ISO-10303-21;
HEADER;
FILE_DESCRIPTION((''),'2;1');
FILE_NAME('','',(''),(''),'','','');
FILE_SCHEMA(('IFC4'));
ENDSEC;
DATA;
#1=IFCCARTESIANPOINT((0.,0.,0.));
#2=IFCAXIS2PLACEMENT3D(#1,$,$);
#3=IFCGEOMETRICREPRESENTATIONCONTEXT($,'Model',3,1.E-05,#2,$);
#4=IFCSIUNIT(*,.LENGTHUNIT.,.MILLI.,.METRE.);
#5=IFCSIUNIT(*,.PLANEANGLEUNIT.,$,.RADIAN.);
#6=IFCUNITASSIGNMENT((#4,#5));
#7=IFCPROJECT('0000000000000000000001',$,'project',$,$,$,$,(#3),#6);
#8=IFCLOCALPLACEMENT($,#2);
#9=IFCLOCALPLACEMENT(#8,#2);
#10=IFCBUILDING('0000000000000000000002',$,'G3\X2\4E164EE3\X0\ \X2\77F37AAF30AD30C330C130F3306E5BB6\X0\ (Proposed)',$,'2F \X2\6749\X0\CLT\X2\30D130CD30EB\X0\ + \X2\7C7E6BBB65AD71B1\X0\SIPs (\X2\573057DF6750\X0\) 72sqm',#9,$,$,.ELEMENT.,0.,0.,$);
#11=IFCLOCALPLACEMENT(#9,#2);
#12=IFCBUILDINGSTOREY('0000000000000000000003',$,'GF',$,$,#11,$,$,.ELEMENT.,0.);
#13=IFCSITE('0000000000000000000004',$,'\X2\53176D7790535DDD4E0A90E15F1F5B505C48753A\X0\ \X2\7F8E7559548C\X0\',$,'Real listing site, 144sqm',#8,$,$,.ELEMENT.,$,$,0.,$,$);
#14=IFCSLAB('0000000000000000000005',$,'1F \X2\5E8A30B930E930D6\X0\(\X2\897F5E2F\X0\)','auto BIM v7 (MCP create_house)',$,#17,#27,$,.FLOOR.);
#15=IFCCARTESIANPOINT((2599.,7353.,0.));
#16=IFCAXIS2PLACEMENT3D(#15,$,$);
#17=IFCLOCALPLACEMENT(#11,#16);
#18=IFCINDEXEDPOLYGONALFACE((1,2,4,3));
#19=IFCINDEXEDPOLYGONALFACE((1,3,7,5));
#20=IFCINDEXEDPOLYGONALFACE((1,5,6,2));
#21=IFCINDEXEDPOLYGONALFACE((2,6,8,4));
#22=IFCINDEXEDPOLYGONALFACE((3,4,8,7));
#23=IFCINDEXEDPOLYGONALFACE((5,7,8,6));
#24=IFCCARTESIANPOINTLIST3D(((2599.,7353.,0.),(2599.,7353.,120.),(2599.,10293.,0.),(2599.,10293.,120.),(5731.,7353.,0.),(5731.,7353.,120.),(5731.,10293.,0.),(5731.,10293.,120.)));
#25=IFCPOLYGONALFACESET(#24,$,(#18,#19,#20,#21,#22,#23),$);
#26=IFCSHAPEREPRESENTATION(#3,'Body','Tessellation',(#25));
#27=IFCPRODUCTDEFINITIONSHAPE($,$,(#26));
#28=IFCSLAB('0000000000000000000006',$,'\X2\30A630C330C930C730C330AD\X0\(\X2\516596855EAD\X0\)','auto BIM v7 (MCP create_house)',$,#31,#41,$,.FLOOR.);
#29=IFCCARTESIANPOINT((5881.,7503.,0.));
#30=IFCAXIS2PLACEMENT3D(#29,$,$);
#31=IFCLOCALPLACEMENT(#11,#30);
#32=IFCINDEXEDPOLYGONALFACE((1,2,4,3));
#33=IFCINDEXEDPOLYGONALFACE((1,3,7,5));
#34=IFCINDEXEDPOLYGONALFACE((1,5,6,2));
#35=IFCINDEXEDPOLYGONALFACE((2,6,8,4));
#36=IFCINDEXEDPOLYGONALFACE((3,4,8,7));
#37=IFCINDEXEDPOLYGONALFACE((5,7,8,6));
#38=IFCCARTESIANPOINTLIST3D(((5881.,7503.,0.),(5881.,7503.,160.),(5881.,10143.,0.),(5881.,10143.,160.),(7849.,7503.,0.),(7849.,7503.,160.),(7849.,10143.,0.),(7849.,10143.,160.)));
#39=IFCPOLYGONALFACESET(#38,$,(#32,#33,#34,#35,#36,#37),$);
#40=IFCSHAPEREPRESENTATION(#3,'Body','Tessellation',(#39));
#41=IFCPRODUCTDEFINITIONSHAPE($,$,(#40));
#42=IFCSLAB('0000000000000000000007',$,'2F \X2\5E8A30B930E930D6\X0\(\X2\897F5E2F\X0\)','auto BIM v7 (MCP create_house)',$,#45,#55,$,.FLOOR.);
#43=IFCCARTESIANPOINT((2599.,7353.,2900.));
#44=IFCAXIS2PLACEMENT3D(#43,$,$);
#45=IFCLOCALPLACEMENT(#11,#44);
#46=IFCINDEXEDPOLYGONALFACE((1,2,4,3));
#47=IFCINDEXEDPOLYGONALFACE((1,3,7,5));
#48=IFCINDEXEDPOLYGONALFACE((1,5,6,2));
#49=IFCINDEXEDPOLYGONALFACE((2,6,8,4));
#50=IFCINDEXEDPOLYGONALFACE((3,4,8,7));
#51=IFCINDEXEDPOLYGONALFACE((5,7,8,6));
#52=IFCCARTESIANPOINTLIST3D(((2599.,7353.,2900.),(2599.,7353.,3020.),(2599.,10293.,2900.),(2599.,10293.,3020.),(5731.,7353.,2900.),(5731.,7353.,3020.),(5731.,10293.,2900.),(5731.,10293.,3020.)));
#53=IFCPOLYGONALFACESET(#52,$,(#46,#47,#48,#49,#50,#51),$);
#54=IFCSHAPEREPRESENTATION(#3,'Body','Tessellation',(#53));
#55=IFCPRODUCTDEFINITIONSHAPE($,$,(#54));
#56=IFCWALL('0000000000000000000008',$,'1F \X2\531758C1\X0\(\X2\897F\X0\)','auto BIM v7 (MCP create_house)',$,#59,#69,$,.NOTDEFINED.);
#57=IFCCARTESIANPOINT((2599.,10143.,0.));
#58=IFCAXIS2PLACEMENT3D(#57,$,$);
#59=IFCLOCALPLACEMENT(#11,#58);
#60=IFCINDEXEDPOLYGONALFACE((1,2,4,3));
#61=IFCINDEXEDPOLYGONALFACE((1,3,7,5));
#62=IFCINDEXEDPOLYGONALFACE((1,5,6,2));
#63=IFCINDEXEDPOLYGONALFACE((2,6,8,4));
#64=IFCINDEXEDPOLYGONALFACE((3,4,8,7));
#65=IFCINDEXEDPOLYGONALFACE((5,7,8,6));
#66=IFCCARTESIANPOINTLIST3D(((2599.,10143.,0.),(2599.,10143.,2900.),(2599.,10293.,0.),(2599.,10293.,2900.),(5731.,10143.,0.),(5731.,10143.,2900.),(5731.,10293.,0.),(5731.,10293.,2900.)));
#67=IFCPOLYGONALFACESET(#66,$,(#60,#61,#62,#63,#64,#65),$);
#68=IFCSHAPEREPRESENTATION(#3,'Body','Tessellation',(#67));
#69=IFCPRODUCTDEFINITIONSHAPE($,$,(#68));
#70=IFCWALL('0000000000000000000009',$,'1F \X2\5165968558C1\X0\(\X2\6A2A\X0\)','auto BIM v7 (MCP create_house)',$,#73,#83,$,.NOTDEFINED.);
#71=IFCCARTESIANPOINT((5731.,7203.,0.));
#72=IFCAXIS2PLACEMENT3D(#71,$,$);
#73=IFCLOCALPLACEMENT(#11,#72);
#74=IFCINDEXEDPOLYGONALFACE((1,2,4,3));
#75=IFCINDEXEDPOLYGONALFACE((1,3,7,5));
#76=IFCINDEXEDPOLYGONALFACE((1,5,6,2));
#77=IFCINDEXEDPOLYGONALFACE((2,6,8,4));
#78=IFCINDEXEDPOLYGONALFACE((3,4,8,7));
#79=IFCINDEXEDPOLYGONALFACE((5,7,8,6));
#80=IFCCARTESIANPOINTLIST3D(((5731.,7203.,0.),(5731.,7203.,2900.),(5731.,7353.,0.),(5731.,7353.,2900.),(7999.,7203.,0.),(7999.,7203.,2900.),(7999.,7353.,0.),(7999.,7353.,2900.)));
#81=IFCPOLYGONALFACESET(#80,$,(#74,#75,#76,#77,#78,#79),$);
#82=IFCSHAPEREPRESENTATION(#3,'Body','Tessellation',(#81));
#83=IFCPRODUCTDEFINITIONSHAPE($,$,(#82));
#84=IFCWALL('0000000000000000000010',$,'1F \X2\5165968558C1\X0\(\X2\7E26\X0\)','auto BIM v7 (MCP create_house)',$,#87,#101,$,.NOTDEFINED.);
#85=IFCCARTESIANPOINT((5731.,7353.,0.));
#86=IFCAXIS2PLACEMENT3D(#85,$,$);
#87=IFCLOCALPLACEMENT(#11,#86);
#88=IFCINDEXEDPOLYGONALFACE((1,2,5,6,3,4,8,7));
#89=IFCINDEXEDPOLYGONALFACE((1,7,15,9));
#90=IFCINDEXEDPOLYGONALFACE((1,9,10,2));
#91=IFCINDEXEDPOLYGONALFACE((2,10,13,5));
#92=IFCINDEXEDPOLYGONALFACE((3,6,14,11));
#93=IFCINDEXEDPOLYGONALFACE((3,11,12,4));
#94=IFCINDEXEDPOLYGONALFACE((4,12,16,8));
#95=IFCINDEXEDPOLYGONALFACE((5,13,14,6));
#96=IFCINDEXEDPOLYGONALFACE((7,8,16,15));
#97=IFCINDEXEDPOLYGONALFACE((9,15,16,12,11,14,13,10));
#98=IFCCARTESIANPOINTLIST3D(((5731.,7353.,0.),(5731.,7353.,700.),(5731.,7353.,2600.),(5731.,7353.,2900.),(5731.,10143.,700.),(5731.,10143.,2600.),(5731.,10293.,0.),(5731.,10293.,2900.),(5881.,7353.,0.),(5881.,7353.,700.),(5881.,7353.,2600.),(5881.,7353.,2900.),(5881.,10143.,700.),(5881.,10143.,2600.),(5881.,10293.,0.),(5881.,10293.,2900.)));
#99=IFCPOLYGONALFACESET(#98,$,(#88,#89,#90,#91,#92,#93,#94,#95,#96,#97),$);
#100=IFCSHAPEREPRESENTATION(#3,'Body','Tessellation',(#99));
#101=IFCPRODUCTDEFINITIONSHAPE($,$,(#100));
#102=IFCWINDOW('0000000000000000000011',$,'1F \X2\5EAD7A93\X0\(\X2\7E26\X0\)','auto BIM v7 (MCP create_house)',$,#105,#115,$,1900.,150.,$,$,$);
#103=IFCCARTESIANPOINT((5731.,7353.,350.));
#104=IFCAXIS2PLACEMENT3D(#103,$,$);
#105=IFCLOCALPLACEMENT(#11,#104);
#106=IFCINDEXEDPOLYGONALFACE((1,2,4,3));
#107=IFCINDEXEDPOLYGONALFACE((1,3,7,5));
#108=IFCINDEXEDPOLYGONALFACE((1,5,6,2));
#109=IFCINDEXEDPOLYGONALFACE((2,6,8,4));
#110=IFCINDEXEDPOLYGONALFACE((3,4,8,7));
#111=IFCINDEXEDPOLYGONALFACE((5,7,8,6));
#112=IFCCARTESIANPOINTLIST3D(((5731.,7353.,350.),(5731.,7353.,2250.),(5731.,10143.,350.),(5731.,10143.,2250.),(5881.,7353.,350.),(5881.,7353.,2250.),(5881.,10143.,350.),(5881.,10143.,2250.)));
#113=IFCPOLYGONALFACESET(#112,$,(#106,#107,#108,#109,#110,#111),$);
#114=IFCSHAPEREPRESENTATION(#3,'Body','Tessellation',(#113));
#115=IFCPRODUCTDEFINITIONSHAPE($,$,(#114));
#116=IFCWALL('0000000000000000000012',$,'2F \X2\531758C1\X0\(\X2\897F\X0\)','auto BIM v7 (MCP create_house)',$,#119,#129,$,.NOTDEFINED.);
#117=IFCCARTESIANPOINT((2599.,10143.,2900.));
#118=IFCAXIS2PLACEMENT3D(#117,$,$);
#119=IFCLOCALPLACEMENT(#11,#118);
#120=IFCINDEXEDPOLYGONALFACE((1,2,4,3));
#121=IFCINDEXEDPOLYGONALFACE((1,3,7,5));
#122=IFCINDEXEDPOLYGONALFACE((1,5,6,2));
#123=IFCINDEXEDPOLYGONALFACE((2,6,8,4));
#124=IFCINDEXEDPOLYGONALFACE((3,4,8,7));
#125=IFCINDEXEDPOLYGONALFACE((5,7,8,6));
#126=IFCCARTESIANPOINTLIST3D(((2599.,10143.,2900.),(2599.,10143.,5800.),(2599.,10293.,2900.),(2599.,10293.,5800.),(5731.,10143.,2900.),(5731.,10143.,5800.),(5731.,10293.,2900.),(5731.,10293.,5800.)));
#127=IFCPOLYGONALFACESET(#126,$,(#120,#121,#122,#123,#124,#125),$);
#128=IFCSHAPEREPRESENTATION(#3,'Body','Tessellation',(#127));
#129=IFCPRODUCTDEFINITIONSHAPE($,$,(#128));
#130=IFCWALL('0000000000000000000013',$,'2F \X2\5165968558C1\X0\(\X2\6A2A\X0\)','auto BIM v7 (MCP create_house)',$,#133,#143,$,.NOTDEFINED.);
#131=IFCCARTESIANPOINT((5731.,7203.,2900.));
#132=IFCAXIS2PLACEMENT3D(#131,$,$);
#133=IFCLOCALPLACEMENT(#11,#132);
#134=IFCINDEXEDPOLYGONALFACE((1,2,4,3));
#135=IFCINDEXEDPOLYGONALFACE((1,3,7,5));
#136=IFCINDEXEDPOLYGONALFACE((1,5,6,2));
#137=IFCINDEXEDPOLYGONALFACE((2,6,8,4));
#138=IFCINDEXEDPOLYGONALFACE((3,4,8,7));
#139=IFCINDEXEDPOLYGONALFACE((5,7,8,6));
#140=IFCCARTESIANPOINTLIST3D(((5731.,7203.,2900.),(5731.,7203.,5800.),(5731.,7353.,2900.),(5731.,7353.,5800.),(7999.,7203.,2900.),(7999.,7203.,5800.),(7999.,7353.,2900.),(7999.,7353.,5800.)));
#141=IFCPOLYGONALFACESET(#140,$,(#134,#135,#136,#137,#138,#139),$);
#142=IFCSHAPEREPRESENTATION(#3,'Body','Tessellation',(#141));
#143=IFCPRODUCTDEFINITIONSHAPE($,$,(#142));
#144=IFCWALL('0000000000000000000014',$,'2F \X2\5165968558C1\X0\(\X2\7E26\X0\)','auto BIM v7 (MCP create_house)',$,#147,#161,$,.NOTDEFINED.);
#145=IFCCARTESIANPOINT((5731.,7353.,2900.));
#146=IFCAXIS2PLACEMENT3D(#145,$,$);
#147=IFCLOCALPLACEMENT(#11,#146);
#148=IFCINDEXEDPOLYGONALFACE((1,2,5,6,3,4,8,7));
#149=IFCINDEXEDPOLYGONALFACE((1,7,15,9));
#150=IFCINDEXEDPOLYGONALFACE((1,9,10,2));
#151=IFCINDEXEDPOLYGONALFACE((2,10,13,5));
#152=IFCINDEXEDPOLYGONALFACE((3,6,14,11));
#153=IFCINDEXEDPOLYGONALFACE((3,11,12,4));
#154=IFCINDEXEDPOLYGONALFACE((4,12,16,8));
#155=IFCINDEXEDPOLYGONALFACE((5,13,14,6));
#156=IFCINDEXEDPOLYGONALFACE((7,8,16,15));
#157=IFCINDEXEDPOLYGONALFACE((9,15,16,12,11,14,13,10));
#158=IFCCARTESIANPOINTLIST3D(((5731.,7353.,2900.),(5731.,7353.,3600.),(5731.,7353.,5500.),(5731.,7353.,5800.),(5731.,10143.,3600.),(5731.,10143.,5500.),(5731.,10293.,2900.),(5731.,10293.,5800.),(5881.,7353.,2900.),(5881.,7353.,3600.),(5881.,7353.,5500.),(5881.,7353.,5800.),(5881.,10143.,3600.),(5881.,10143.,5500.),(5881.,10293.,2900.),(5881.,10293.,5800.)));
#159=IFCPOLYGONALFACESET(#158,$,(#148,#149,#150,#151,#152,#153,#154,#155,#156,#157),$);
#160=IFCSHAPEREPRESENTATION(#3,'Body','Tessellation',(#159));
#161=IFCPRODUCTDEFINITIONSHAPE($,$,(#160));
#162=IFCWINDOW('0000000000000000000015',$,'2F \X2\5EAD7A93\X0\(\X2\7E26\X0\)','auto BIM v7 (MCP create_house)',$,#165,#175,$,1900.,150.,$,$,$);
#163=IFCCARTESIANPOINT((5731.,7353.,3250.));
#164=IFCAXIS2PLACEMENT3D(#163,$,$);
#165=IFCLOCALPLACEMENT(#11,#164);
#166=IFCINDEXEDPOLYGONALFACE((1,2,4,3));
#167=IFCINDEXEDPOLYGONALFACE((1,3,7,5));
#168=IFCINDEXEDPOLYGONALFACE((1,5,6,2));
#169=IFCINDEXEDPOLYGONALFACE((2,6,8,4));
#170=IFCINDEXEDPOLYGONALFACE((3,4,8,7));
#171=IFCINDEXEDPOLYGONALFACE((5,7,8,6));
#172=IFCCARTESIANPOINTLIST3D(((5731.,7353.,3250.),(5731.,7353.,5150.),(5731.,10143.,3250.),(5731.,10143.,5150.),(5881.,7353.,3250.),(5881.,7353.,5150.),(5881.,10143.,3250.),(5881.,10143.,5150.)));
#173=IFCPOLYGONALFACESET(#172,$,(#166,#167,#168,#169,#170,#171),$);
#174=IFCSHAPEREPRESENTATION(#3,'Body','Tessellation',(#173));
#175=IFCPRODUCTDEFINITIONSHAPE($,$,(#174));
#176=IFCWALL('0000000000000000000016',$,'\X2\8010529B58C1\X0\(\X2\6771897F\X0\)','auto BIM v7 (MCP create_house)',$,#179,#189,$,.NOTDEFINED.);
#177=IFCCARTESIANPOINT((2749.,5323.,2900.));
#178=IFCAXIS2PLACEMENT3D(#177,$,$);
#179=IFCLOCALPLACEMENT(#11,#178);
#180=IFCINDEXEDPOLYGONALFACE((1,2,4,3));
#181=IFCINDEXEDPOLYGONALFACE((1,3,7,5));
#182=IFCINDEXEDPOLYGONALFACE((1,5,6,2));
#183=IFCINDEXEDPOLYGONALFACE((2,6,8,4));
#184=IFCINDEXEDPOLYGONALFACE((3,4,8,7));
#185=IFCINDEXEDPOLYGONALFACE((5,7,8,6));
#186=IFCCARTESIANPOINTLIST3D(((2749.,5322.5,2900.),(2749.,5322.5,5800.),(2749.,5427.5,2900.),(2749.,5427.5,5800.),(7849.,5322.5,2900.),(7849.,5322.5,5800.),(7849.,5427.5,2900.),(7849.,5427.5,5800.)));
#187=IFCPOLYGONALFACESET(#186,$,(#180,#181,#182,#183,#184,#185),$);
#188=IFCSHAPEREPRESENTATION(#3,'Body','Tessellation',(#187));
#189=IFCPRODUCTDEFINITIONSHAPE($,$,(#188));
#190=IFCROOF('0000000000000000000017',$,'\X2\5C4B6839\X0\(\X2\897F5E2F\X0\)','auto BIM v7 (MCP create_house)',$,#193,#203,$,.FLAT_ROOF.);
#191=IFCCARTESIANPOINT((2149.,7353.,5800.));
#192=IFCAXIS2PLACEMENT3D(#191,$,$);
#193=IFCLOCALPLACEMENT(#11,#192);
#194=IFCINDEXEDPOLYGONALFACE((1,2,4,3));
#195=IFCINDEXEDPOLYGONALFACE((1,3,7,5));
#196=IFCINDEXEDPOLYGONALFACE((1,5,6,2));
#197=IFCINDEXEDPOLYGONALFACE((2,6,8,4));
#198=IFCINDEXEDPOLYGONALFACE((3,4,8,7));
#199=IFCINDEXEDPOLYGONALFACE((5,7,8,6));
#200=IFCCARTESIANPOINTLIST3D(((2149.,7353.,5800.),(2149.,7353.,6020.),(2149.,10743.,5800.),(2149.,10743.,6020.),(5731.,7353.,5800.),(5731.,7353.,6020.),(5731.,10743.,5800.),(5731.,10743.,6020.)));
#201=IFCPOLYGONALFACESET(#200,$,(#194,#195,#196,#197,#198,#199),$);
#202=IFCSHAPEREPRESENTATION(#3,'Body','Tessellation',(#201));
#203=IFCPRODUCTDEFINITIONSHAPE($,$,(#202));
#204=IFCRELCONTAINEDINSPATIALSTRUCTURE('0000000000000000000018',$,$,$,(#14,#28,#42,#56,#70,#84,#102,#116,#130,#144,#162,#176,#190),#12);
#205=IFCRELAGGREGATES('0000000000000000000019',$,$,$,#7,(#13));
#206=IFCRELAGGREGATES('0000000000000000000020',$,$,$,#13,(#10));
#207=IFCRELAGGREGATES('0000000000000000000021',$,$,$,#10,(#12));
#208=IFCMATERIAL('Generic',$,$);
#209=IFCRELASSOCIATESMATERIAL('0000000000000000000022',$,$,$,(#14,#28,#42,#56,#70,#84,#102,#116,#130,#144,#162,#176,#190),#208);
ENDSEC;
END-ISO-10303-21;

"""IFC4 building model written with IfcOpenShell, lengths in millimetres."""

from ifc_helpers import new_model, si_unit, frame, frame_2d, origin, place, context, project, spatial, rectangle, extrude, material, element, fill, save


model = new_model("IFC4")

# Units and contexts
model_context = context("Model", 3, precision=1e-05, world=origin())
ifc_project = project(units=[si_unit("LENGTHUNIT", "METRE", prefix="MILLI"), si_unit("PLANEANGLEUNIT", "RADIAN")], contexts=[model_context])

# Site, building, storey
site_placement = place(None, origin())
site = spatial("IfcSite", under=ifc_project, at=site_placement, Name="北海道川上郡弟子屈町 美留和", ObjectType="Real listing site, 144sqm", CompositionType="ELEMENT", RefElevation=0.0)
building_placement = place(site_placement, origin())
building = spatial("IfcBuilding", under=site, at=building_placement, Name="G3世代 石窯キッチンの家 (Proposed)", ObjectType="2F 杉CLTパネル + 籾殻断熱SIPs (地域材) 72sqm", CompositionType="ELEMENT", ElevationOfRefHeight=0.0, ElevationOfTerrain=0.0)
storey_placement = place(building_placement, origin())
storey = spatial("IfcBuildingStorey", under=building, at=storey_placement, Name="GF", CompositionType="ELEMENT", Elevation=0.0)

# Slabs
ifc_material = material(Name="Generic")
slab_1_placement = place(storey_placement, frame((2599.0, 7353.0, 0.0)))
element("IfcSlab", 1, at=slab_1_placement, inside=storey, material=ifc_material, Name="1F 床スラブ(西帯)", Description="auto BIM v7 (MCP create_house)", PredefinedType="FLOOR", context=model_context, shape_type="SweptSolid", body=[
    extrude(rectangle(XDim=3132.0, YDim=2940.0, at=frame_2d((1566.0, 1470.0))), frame((2599.0, 7353.0, 0.0)), (0.0, 0.0, 1.0), 120.0),
])
slab_2_placement = place(storey_placement, frame((5881.0, 7503.0, 0.0)))
element("IfcSlab", 2, at=slab_2_placement, inside=storey, material=ifc_material, Name="ウッドデッキ(入隅庭)", Description="auto BIM v7 (MCP create_house)", PredefinedType="FLOOR", context=model_context, shape_type="SweptSolid", body=[
    extrude(rectangle(XDim=1968.0, YDim=2640.0, at=frame_2d((984.0, 1320.0))), frame((5881.0, 7503.0, 0.0)), (0.0, 0.0, 1.0), 160.0),
])
slab_3_placement = place(storey_placement, frame((2599.0, 7353.0, 2900.0)))
element("IfcSlab", 3, at=slab_3_placement, inside=storey, material=ifc_material, Name="2F 床スラブ(西帯)", Description="auto BIM v7 (MCP create_house)", PredefinedType="FLOOR", context=model_context, shape_type="SweptSolid", body=[
    extrude(rectangle(XDim=3132.0, YDim=2940.0, at=frame_2d((1566.0, 1470.0))), frame((2599.0, 7353.0, 2900.0)), (0.0, 0.0, 1.0), 120.0),
])

# Walls
wall_1_placement = place(storey_placement, frame((2599.0, 10143.0, 0.0)))
element("IfcWall", 4, at=wall_1_placement, inside=storey, material=ifc_material, Name="1F 北壁(西)", Description="auto BIM v7 (MCP create_house)", PredefinedType="NOTDEFINED", context=model_context, shape_type="SweptSolid", body=[
    extrude(rectangle(XDim=3132.0, YDim=150.0, at=frame_2d((1566.0, 75.0))), frame((2599.0, 10143.0, 0.0)), (0.0, 0.0, 1.0), 2900.0),
])
wall_2_placement = place(storey_placement, frame((5731.0, 7203.0, 0.0)))
element("IfcWall", 5, at=wall_2_placement, inside=storey, material=ifc_material, Name="1F 入隅壁(横)", Description="auto BIM v7 (MCP create_house)", PredefinedType="NOTDEFINED", context=model_context, shape_type="SweptSolid", body=[
    extrude(rectangle(XDim=2268.0, YDim=150.0, at=frame_2d((1134.0, 75.0))), frame((5731.0, 7203.0, 0.0)), (0.0, 0.0, 1.0), 2900.0),
])

# Wall, opening, window
wall_3_placement = place(storey_placement, frame((5731.0, 7353.0, 0.0)))
wall_3 = element("IfcWall", 6, at=wall_3_placement, inside=storey, material=ifc_material, Name="1F 入隅壁(縦)", Description="auto BIM v7 (MCP create_house)", PredefinedType="NOTDEFINED", context=model_context, shape_type="SweptSolid", body=[
    extrude(rectangle(XDim=150.0, YDim=2940.0, at=frame_2d((75.0, 1470.0))), frame((5731.0, 7353.0, 0.0)), (0.0, 0.0, 1.0), 2900.0),
])
opening_1_placement = place(storey_placement, frame((5731.0, 7353.0, 350.0)))
opening_1 = element("IfcOpeningElement", 7, at=opening_1_placement, cuts=wall_3, PredefinedType="NOTDEFINED", context=model_context, shape_type="SweptSolid", body=[
    extrude(rectangle(XDim=150.0, YDim=2790.0, at=frame_2d((75.0, 1395.0))), frame((5731.0, 7353.0, 350.0)), (0.0, 0.0, 1.0), 1900.0),
])
window_1_placement = place(storey_placement, frame((5731.0, 7353.0, 350.0)))
window_1 = element("IfcWindow", 8, at=window_1_placement, inside=storey, material=ifc_material, Name="1F 庭窓(縦)", Description="auto BIM v7 (MCP create_house)", OverallHeight=1900.0, OverallWidth=150.0, context=model_context, shape_type="SweptSolid", body=[
    extrude(rectangle(XDim=150.0, YDim=2790.0, at=frame_2d((75.0, 1395.0))), frame((5731.0, 7353.0, 350.0)), (0.0, 0.0, 1.0), 1900.0),
])
fill(opening_1, window_1)

# Walls
wall_4_placement = place(storey_placement, frame((2599.0, 10143.0, 2900.0)))
element("IfcWall", 9, at=wall_4_placement, inside=storey, material=ifc_material, Name="2F 北壁(西)", Description="auto BIM v7 (MCP create_house)", PredefinedType="NOTDEFINED", context=model_context, shape_type="SweptSolid", body=[
    extrude(rectangle(XDim=3132.0, YDim=150.0, at=frame_2d((1566.0, 75.0))), frame((2599.0, 10143.0, 2900.0)), (0.0, 0.0, 1.0), 2900.0),
])
wall_5_placement = place(storey_placement, frame((5731.0, 7203.0, 2900.0)))
element("IfcWall", 10, at=wall_5_placement, inside=storey, material=ifc_material, Name="2F 入隅壁(横)", Description="auto BIM v7 (MCP create_house)", PredefinedType="NOTDEFINED", context=model_context, shape_type="SweptSolid", body=[
    extrude(rectangle(XDim=2268.0, YDim=150.0, at=frame_2d((1134.0, 75.0))), frame((5731.0, 7203.0, 2900.0)), (0.0, 0.0, 1.0), 2900.0),
])

# Wall, opening, window
wall_6_placement = place(storey_placement, frame((5731.0, 7353.0, 2900.0)))
wall_6 = element("IfcWall", 11, at=wall_6_placement, inside=storey, material=ifc_material, Name="2F 入隅壁(縦)", Description="auto BIM v7 (MCP create_house)", PredefinedType="NOTDEFINED", context=model_context, shape_type="SweptSolid", body=[
    extrude(rectangle(XDim=150.0, YDim=2940.0, at=frame_2d((75.0, 1470.0))), frame((5731.0, 7353.0, 2900.0)), (0.0, 0.0, 1.0), 2900.0),
])
opening_2_placement = place(storey_placement, frame((5731.0, 7353.0, 3250.0)))
opening_2 = element("IfcOpeningElement", 12, at=opening_2_placement, cuts=wall_6, PredefinedType="NOTDEFINED", context=model_context, shape_type="SweptSolid", body=[
    extrude(rectangle(XDim=150.0, YDim=2790.0, at=frame_2d((75.0, 1395.0))), frame((5731.0, 7353.0, 3250.0)), (0.0, 0.0, 1.0), 1900.0),
])
window_2_placement = place(storey_placement, frame((5731.0, 7353.0, 3250.0)))
window_2 = element("IfcWindow", 13, at=window_2_placement, inside=storey, material=ifc_material, Name="2F 庭窓(縦)", Description="auto BIM v7 (MCP create_house)", OverallHeight=1900.0, OverallWidth=150.0, context=model_context, shape_type="SweptSolid", body=[
    extrude(rectangle(XDim=150.0, YDim=2790.0, at=frame_2d((75.0, 1395.0))), frame((5731.0, 7353.0, 3250.0)), (0.0, 0.0, 1.0), 1900.0),
])
fill(opening_2, window_2)

# Wall
wall_7_placement = place(storey_placement, frame((2749.0, 5323.0, 2900.0)))
element("IfcWall", 14, at=wall_7_placement, inside=storey, material=ifc_material, Name="耐力壁(東西)", Description="auto BIM v7 (MCP create_house)", PredefinedType="NOTDEFINED", context=model_context, shape_type="SweptSolid", body=[
    extrude(rectangle(XDim=5100.0, YDim=105.0, at=frame_2d((2550.0, 52.0))), frame((2749.0, 5323.0, 2900.0)), (0.0, 0.0, 1.0), 2900.0),
])

# Roof
for number, where, name in (
    (15, (2149.0, 7353.0, 5800.0), "屋根(西帯)"),
):
    element("IfcRoof", number, at=place(storey_placement, frame(where)), inside=storey, material=ifc_material, Name=name, Description="auto BIM v7 (MCP create_house)", PredefinedType="FLAT_ROOF", context=model_context, shape_type="SweptSolid", body=[
        extrude(rectangle(XDim=3582.0, YDim=3390.0, at=frame_2d((1791.0, 1695.0))), frame((2149.0, 7353.0, 5800.0)), (0.0, 0.0, 1.0), 220.0),
    ])

save(model, "model.ifc")
